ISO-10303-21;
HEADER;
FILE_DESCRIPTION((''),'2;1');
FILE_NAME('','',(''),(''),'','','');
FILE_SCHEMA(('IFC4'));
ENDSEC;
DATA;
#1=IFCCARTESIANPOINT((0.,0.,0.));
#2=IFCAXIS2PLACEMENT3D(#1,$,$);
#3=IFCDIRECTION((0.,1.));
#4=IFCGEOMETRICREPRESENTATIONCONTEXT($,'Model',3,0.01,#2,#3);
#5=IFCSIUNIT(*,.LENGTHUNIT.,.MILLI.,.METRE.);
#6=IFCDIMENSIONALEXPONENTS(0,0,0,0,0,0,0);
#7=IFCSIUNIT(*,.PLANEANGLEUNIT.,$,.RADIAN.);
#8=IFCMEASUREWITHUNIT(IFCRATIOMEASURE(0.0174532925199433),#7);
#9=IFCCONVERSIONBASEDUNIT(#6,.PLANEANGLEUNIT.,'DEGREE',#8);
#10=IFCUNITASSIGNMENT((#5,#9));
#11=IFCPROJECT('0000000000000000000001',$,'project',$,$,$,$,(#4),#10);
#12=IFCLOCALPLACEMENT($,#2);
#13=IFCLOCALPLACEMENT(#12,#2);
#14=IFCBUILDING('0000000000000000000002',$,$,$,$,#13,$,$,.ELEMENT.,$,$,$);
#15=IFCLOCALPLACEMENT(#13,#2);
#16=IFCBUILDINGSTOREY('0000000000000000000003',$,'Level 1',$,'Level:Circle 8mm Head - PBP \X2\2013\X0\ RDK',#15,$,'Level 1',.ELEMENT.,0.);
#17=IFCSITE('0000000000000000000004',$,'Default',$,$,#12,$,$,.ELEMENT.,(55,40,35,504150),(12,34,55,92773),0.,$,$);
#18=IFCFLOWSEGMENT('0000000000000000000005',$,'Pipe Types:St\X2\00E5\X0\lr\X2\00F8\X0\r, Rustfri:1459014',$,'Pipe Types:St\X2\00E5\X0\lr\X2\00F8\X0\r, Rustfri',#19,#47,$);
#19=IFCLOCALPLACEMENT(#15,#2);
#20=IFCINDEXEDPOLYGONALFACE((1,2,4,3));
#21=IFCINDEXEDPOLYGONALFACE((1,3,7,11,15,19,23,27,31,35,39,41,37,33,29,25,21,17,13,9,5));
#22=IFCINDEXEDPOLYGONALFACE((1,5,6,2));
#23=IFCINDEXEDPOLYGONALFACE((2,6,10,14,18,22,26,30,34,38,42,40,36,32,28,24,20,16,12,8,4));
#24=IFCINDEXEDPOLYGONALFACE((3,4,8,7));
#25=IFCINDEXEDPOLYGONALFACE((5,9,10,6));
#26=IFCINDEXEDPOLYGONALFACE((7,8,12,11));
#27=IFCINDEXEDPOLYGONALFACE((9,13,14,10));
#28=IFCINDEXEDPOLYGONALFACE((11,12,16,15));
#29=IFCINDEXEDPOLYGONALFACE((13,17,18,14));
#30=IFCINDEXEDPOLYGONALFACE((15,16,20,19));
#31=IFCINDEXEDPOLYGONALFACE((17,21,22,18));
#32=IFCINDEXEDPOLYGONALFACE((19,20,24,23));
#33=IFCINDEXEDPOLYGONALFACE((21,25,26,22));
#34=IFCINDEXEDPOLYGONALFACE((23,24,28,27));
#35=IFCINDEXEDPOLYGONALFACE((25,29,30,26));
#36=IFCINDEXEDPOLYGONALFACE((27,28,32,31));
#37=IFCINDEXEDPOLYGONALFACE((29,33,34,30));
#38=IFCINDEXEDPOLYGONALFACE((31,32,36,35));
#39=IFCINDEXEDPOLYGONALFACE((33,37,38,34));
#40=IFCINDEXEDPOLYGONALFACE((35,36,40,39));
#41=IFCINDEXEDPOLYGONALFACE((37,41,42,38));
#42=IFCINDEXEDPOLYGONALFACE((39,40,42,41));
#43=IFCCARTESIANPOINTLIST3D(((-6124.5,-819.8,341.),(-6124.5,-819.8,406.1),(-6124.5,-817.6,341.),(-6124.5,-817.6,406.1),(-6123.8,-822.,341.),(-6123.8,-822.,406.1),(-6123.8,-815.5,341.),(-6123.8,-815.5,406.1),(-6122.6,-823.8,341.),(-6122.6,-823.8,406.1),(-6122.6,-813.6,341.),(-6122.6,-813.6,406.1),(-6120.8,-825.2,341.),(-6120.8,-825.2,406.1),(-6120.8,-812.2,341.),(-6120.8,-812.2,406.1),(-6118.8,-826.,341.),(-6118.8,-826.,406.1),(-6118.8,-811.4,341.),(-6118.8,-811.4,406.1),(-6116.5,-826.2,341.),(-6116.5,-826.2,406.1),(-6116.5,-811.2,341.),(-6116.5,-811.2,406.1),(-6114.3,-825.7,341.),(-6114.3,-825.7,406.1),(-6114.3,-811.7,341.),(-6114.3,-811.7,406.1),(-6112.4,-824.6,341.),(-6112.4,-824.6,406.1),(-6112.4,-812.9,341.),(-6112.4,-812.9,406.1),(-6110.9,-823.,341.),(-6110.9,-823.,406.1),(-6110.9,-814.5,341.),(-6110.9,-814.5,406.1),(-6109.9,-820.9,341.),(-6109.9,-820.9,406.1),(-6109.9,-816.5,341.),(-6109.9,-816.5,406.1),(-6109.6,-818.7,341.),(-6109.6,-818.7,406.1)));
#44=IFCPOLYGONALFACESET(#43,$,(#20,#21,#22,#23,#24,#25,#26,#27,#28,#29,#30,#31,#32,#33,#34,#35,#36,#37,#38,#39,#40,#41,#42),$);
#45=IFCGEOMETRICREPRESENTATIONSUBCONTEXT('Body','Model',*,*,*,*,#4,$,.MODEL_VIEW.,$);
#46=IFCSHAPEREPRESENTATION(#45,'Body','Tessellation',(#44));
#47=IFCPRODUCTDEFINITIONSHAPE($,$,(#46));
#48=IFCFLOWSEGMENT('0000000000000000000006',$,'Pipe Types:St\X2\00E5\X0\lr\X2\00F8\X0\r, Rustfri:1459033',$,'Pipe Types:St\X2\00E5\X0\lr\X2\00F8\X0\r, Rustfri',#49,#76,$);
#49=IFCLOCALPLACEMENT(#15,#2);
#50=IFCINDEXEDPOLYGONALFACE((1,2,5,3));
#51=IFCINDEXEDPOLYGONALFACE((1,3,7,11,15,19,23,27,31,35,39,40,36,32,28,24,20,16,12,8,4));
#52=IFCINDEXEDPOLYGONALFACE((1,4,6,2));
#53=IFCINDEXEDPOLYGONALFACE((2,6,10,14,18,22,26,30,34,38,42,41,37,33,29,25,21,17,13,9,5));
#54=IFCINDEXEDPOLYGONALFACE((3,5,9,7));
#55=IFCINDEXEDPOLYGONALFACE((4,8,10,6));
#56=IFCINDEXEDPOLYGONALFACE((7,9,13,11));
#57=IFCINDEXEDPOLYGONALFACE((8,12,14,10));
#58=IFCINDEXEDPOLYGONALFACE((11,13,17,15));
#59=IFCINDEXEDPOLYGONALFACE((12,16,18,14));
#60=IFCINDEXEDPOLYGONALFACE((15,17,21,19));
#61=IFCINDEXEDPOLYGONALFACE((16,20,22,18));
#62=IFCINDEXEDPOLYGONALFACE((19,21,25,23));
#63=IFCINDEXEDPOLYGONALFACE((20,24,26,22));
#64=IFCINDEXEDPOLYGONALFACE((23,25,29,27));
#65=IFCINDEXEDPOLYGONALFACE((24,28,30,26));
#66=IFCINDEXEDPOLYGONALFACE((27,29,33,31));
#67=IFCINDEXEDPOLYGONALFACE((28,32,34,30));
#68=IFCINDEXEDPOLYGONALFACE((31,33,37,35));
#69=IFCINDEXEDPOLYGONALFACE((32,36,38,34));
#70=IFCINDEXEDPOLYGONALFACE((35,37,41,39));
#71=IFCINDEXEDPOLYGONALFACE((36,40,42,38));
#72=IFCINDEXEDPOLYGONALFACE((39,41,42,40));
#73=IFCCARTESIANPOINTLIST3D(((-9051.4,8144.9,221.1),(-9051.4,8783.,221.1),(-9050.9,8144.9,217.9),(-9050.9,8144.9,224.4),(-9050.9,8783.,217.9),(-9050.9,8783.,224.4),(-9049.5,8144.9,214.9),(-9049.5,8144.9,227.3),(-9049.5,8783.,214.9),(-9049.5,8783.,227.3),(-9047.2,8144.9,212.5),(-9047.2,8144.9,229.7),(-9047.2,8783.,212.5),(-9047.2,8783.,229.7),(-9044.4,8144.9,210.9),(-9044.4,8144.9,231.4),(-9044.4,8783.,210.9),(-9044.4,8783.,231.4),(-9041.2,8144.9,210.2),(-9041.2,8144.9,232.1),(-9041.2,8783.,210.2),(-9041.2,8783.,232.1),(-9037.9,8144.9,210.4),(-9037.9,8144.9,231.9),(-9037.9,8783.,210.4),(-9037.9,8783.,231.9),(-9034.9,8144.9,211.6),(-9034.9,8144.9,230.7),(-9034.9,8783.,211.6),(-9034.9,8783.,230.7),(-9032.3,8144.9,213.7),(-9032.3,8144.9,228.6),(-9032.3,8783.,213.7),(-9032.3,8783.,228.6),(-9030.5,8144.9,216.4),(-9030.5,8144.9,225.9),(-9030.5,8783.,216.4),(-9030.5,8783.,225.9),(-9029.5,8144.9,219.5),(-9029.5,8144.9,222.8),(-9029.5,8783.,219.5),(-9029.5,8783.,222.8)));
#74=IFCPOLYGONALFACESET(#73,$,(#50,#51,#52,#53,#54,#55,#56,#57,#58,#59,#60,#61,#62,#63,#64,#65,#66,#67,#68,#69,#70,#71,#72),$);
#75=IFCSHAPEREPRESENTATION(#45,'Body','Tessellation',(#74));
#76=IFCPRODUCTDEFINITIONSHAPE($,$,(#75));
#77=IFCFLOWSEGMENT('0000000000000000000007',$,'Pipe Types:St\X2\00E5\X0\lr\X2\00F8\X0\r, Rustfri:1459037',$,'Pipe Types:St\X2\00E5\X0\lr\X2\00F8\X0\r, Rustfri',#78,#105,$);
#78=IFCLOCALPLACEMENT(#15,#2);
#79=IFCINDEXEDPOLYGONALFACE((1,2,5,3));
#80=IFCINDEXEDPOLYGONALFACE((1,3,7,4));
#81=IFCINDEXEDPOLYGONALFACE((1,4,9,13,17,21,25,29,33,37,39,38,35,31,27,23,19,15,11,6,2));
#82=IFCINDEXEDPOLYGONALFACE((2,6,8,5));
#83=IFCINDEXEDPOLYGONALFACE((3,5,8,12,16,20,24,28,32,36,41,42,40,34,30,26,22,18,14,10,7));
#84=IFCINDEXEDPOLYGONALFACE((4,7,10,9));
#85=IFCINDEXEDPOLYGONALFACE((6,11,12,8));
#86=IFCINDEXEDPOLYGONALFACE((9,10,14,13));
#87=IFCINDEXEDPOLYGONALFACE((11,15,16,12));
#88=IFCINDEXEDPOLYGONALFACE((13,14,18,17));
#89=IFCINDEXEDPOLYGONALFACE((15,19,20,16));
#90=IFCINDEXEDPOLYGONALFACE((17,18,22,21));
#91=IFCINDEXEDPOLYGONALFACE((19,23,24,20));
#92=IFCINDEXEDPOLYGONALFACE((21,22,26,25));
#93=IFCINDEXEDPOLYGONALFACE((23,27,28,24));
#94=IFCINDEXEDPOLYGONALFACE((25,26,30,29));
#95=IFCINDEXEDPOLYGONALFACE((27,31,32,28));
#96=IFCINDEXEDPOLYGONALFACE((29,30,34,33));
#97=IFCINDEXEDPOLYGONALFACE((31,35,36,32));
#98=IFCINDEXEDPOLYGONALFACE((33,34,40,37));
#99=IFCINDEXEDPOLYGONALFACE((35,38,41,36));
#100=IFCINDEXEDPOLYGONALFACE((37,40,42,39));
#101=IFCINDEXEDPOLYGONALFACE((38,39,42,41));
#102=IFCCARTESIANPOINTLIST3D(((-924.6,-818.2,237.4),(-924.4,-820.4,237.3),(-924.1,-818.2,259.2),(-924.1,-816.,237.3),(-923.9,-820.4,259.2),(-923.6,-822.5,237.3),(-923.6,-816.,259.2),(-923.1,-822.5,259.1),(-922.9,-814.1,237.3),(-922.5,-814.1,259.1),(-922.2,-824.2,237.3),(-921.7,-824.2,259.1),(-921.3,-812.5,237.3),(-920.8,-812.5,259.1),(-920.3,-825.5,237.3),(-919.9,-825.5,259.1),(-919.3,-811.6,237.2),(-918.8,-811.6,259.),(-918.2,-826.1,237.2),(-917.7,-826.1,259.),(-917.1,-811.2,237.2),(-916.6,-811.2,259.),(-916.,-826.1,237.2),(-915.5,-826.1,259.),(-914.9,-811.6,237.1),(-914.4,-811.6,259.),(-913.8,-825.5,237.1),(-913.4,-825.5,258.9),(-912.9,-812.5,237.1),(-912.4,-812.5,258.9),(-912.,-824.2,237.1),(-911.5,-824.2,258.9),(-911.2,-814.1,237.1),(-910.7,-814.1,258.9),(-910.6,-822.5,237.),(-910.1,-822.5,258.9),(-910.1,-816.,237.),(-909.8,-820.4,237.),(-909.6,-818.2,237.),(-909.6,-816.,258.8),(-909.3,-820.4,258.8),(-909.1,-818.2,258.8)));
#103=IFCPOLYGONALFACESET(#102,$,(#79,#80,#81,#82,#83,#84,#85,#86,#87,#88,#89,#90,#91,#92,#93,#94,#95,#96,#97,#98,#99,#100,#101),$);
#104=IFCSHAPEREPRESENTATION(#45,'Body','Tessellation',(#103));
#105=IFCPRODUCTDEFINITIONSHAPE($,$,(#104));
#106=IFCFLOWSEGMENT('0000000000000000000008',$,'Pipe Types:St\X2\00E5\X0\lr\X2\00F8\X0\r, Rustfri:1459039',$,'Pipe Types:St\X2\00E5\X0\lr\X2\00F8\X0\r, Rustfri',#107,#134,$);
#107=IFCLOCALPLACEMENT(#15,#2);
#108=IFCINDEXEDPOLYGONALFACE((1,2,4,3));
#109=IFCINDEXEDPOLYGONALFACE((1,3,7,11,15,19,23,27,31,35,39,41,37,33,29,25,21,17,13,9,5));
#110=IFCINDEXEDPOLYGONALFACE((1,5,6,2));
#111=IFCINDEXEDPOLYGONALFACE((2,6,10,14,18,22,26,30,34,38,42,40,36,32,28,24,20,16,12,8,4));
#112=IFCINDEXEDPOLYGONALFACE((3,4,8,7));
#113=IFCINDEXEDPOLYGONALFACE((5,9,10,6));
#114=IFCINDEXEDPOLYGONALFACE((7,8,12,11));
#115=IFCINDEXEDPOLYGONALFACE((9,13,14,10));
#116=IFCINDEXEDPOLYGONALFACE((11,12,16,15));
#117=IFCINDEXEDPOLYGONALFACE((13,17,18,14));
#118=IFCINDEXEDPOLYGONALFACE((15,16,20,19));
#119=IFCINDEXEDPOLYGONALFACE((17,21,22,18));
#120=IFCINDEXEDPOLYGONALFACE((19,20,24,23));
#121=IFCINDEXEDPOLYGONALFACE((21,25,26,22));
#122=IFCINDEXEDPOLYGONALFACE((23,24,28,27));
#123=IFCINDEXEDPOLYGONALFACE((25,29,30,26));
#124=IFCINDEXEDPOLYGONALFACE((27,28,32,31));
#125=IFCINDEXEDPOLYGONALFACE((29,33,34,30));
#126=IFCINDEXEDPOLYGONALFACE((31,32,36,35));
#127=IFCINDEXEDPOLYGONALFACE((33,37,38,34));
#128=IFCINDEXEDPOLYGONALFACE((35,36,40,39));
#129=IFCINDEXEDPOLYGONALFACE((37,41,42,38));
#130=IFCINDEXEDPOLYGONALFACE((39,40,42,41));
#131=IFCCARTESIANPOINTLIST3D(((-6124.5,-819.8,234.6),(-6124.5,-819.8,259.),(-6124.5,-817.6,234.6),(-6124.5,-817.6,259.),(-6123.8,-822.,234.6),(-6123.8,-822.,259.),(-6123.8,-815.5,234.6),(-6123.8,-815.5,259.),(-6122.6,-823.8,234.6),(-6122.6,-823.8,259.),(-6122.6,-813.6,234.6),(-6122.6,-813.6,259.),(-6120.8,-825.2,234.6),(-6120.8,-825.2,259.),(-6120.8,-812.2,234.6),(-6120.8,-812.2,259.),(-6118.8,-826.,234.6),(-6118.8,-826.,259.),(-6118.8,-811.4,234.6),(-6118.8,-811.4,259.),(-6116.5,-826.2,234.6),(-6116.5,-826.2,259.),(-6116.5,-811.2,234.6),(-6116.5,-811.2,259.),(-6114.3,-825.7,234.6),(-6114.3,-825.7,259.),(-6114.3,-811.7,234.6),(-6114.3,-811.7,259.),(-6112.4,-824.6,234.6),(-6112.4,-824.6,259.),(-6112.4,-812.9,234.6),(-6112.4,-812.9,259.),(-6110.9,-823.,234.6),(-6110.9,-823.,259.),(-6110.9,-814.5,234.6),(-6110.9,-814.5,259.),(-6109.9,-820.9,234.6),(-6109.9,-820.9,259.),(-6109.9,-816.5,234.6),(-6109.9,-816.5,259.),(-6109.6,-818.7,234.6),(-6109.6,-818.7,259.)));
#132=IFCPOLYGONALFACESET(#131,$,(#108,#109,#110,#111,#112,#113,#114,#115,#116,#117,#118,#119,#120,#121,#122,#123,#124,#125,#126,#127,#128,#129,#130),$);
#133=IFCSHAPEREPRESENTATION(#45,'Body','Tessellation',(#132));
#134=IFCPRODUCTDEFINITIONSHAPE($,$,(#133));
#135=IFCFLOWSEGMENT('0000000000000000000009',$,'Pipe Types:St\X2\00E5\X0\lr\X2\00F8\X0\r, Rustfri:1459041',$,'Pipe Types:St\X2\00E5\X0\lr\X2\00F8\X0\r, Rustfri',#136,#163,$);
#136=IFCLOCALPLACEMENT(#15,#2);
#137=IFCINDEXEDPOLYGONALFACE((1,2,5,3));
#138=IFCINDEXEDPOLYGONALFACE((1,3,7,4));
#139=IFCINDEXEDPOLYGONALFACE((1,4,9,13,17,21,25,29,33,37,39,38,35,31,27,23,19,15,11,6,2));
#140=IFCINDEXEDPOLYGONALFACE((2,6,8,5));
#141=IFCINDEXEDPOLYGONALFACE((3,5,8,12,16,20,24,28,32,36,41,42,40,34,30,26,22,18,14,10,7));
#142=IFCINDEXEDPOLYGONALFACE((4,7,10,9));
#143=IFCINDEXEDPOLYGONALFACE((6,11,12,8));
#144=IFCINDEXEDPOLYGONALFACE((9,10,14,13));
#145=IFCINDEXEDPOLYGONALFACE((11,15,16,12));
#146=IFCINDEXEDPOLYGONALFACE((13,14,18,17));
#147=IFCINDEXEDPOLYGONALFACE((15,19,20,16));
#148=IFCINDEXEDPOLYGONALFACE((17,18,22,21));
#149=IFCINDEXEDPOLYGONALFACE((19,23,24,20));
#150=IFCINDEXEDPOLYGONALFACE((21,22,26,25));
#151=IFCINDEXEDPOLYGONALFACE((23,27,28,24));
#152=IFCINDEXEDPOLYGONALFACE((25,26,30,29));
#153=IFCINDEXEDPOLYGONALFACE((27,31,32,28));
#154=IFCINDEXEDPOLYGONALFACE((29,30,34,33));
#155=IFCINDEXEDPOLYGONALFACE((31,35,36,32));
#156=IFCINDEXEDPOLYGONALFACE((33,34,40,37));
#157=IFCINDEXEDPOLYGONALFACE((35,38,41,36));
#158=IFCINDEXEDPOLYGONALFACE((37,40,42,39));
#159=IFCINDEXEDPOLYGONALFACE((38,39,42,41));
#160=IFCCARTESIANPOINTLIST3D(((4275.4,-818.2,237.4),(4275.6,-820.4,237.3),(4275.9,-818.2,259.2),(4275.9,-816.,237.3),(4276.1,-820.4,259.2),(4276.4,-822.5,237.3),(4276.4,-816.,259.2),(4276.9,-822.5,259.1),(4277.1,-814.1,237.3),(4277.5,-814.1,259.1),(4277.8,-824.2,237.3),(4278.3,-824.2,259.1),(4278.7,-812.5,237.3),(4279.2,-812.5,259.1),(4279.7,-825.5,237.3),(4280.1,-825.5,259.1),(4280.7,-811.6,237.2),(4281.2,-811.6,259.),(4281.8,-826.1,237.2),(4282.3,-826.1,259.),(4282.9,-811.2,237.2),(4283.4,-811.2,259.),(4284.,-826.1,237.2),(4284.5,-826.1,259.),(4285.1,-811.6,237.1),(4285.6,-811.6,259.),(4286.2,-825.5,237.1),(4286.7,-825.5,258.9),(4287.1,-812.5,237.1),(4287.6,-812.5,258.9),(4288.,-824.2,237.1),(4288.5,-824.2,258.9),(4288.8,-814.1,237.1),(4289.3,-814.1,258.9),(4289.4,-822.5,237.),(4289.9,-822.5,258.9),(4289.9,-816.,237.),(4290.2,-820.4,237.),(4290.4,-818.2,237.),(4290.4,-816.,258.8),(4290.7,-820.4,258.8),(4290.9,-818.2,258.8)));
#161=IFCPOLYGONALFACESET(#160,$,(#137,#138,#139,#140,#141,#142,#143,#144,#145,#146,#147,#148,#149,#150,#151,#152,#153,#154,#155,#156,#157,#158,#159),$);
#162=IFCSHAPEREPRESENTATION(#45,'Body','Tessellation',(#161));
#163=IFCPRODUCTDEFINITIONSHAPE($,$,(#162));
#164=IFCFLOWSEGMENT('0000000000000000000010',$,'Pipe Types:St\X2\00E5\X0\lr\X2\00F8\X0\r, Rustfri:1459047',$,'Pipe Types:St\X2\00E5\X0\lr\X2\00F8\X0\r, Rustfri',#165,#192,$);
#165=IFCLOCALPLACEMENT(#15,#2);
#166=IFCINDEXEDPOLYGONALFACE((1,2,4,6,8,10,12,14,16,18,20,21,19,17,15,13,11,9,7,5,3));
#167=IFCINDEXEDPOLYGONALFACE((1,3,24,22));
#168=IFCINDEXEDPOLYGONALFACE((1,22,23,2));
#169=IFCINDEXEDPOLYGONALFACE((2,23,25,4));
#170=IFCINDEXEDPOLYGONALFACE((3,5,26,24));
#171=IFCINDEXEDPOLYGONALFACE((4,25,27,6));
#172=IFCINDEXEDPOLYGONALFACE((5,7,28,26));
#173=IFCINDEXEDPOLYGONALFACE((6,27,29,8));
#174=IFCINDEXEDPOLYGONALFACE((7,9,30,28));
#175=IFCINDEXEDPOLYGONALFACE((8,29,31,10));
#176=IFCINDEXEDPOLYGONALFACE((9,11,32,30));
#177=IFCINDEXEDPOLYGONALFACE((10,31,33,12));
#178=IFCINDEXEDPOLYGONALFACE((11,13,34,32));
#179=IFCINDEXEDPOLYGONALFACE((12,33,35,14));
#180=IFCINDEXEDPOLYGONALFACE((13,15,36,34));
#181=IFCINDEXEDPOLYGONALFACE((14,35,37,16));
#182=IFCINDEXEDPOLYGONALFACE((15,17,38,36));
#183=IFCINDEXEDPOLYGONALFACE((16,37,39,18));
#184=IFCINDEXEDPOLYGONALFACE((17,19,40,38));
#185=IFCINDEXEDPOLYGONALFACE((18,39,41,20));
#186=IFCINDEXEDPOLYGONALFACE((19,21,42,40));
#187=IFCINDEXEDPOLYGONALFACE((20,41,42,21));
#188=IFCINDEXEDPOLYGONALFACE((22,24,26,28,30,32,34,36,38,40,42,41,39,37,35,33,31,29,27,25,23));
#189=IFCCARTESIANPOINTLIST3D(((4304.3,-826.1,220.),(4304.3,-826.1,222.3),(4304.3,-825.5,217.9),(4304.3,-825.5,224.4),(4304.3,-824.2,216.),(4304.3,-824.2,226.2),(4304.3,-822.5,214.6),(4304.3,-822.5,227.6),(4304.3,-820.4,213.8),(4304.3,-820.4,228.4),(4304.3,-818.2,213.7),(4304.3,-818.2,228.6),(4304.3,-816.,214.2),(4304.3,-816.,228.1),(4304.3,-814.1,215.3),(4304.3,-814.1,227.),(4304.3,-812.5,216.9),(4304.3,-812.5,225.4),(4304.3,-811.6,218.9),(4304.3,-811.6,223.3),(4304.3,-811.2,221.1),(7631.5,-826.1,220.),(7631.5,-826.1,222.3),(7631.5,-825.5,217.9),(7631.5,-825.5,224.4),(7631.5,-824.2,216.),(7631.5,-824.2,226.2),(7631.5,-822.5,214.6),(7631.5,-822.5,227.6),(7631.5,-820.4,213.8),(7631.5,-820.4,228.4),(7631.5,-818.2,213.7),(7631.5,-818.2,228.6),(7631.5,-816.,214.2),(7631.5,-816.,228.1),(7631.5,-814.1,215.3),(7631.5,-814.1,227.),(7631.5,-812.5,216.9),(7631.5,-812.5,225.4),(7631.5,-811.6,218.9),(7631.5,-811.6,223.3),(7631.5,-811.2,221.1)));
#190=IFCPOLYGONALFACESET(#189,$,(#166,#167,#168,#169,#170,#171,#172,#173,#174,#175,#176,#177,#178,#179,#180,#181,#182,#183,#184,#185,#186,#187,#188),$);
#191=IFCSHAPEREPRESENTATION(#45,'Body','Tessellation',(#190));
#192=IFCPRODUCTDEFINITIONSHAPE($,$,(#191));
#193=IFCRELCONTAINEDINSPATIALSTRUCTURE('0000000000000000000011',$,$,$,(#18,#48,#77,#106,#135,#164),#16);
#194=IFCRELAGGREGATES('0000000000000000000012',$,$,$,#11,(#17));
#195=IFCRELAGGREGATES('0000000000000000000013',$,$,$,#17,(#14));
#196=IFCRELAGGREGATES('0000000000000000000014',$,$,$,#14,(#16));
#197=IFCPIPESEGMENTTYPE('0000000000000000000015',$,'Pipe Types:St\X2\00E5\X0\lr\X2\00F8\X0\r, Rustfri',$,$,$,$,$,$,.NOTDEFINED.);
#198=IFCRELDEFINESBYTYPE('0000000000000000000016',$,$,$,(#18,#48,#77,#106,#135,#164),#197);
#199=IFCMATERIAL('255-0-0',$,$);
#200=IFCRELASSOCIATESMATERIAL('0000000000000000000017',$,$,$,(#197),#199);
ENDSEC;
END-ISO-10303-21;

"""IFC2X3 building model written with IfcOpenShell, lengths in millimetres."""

from ifc_helpers import new_model, entity, si_unit, converted_unit, direction, frame, frame_2d, origin, origin_2d_with_axis, place, context, subcontext, project, spatial, circle, extrude, material, type_object, element, save


model = new_model("IFC2X3")

# Units and contexts
model_context = context("Model", 3, precision=0.01, world=origin(), true_north=direction((0.0, 1.0)))
body_context = subcontext(model_context, "Body", "Model", "MODEL_VIEW")
ifc_project = project(units=[si_unit("LENGTHUNIT", "METRE", prefix="MILLI"), converted_unit("PLANEANGLEUNIT", "DEGREE", entity("IfcRatioMeasure", 0.0174532925199433), si_unit("PLANEANGLEUNIT", "RADIAN"), dimensions=[0, 0, 0, 0, 0, 0, 0])], contexts=[model_context])

# Site, building, storey
site_placement = place(None, origin())
site = spatial("IfcSite", under=ifc_project, at=site_placement, Name="Default", CompositionType="ELEMENT", RefLatitude=(55, 40, 35, 504150), RefLongitude=(12, 34, 55, 92773), RefElevation=0.0)
building_placement = place(site_placement, origin())
building = spatial("IfcBuilding", under=site, at=building_placement, CompositionType="ELEMENT")
storey_placement = place(building_placement, origin())
storey = spatial("IfcBuildingStorey", under=building, at=storey_placement, Name="Level 1", ObjectType="Level:Circle 8mm Head - PBP – RDK", LongName="Level 1", CompositionType="ELEMENT", Elevation=0.0)

# Flow segments
ifc_material = material(Name="255-0-0")
pipe_segment_type = type_object("IfcPipeSegmentType", Name="Pipe Types:Stålrør, Rustfri", PredefinedType="NOTDEFINED", material=ifc_material)
flow_segment_1_placement = place(storey_placement, origin())
element("IfcFlowSegment", 1, at=flow_segment_1_placement, inside=storey, type_object=pipe_segment_type, Name="Pipe Types:Stålrør, Rustfri:1459014", ObjectType="Pipe Types:Stålrør, Rustfri", context=body_context, shape_type="SweptSolid", body=[
    extrude(circle(Radius=7.5, at=origin_2d_with_axis()), frame((-6117.1, -818.7, 341.0)), (0.0, 0.0, 1.0), 65.1),
])
flow_segment_2_placement = place(storey_placement, origin())
element("IfcFlowSegment", 2, at=flow_segment_2_placement, inside=storey, type_object=pipe_segment_type, Name="Pipe Types:Stålrør, Rustfri:1459033", ObjectType="Pipe Types:Stålrør, Rustfri", context=body_context, shape_type="SweptSolid", body=[
    extrude(circle(Radius=11.0, at=frame_2d((0.0, 0.0), x_axis=(1.0, 0.0))), frame((-9040.4, 8144.9, 221.1), z_axis=(0.0, 1.0, 0.0), x_axis=(-1.0, 0.0, 0.0)), (0.0, 0.0, 1.0), 638.0),
])
flow_segment_3_placement = place(storey_placement, origin())
element("IfcFlowSegment", 3, at=flow_segment_3_placement, inside=storey, type_object=pipe_segment_type, Name="Pipe Types:Stålrør, Rustfri:1459037", ObjectType="Pipe Types:Stålrør, Rustfri", context=body_context, shape_type="SweptSolid", body=[
    extrude(circle(Radius=7.5, at=origin_2d_with_axis()), frame((-917.1, -818.7, 237.2), z_axis=(0.02197, 0.0, 0.999759), x_axis=(0.0, 1.0, 0.0)), (0.0, 0.0, 1.0), 21.8),
])
flow_segment_4_placement = place(storey_placement, origin())
element("IfcFlowSegment", 4, at=flow_segment_4_placement, inside=storey, type_object=pipe_segment_type, Name="Pipe Types:Stålrør, Rustfri:1459039", ObjectType="Pipe Types:Stålrør, Rustfri", context=body_context, shape_type="SweptSolid", body=[
    extrude(circle(Radius=7.5, at=origin_2d_with_axis()), frame((-6117.1, -818.7, 234.6)), (0.0, 0.0, 1.0), 24.4),
])
flow_segment_5_placement = place(storey_placement, origin())
element("IfcFlowSegment", 5, at=flow_segment_5_placement, inside=storey, type_object=pipe_segment_type, Name="Pipe Types:Stålrør, Rustfri:1459041", ObjectType="Pipe Types:Stålrør, Rustfri", context=body_context, shape_type="SweptSolid", body=[
    extrude(circle(Radius=7.5, at=origin_2d_with_axis()), frame((4282.9, -818.7, 237.2), z_axis=(0.022114, 0.0, 0.999755), x_axis=(0.0, 1.0, 0.0)), (0.0, 0.0, 1.0), 21.8),
])
flow_segment_6_placement = place(storey_placement, origin())
element("IfcFlowSegment", 6, at=flow_segment_6_placement, inside=storey, type_object=pipe_segment_type, Name="Pipe Types:Stålrør, Rustfri:1459047", ObjectType="Pipe Types:Stålrør, Rustfri", context=body_context, shape_type="SweptSolid", body=[
    extrude(circle(Radius=7.5, at=frame_2d((0.0, 0.0), x_axis=(1.0, 0.0))), frame((4304.3, -818.7, 221.1), z_axis=(1.0, 0.0, 0.0), x_axis=(0.0, 1.0, 0.0)), (0.0, 0.0, 1.0), 3327.2),
])

save(model, "model.ifc")
